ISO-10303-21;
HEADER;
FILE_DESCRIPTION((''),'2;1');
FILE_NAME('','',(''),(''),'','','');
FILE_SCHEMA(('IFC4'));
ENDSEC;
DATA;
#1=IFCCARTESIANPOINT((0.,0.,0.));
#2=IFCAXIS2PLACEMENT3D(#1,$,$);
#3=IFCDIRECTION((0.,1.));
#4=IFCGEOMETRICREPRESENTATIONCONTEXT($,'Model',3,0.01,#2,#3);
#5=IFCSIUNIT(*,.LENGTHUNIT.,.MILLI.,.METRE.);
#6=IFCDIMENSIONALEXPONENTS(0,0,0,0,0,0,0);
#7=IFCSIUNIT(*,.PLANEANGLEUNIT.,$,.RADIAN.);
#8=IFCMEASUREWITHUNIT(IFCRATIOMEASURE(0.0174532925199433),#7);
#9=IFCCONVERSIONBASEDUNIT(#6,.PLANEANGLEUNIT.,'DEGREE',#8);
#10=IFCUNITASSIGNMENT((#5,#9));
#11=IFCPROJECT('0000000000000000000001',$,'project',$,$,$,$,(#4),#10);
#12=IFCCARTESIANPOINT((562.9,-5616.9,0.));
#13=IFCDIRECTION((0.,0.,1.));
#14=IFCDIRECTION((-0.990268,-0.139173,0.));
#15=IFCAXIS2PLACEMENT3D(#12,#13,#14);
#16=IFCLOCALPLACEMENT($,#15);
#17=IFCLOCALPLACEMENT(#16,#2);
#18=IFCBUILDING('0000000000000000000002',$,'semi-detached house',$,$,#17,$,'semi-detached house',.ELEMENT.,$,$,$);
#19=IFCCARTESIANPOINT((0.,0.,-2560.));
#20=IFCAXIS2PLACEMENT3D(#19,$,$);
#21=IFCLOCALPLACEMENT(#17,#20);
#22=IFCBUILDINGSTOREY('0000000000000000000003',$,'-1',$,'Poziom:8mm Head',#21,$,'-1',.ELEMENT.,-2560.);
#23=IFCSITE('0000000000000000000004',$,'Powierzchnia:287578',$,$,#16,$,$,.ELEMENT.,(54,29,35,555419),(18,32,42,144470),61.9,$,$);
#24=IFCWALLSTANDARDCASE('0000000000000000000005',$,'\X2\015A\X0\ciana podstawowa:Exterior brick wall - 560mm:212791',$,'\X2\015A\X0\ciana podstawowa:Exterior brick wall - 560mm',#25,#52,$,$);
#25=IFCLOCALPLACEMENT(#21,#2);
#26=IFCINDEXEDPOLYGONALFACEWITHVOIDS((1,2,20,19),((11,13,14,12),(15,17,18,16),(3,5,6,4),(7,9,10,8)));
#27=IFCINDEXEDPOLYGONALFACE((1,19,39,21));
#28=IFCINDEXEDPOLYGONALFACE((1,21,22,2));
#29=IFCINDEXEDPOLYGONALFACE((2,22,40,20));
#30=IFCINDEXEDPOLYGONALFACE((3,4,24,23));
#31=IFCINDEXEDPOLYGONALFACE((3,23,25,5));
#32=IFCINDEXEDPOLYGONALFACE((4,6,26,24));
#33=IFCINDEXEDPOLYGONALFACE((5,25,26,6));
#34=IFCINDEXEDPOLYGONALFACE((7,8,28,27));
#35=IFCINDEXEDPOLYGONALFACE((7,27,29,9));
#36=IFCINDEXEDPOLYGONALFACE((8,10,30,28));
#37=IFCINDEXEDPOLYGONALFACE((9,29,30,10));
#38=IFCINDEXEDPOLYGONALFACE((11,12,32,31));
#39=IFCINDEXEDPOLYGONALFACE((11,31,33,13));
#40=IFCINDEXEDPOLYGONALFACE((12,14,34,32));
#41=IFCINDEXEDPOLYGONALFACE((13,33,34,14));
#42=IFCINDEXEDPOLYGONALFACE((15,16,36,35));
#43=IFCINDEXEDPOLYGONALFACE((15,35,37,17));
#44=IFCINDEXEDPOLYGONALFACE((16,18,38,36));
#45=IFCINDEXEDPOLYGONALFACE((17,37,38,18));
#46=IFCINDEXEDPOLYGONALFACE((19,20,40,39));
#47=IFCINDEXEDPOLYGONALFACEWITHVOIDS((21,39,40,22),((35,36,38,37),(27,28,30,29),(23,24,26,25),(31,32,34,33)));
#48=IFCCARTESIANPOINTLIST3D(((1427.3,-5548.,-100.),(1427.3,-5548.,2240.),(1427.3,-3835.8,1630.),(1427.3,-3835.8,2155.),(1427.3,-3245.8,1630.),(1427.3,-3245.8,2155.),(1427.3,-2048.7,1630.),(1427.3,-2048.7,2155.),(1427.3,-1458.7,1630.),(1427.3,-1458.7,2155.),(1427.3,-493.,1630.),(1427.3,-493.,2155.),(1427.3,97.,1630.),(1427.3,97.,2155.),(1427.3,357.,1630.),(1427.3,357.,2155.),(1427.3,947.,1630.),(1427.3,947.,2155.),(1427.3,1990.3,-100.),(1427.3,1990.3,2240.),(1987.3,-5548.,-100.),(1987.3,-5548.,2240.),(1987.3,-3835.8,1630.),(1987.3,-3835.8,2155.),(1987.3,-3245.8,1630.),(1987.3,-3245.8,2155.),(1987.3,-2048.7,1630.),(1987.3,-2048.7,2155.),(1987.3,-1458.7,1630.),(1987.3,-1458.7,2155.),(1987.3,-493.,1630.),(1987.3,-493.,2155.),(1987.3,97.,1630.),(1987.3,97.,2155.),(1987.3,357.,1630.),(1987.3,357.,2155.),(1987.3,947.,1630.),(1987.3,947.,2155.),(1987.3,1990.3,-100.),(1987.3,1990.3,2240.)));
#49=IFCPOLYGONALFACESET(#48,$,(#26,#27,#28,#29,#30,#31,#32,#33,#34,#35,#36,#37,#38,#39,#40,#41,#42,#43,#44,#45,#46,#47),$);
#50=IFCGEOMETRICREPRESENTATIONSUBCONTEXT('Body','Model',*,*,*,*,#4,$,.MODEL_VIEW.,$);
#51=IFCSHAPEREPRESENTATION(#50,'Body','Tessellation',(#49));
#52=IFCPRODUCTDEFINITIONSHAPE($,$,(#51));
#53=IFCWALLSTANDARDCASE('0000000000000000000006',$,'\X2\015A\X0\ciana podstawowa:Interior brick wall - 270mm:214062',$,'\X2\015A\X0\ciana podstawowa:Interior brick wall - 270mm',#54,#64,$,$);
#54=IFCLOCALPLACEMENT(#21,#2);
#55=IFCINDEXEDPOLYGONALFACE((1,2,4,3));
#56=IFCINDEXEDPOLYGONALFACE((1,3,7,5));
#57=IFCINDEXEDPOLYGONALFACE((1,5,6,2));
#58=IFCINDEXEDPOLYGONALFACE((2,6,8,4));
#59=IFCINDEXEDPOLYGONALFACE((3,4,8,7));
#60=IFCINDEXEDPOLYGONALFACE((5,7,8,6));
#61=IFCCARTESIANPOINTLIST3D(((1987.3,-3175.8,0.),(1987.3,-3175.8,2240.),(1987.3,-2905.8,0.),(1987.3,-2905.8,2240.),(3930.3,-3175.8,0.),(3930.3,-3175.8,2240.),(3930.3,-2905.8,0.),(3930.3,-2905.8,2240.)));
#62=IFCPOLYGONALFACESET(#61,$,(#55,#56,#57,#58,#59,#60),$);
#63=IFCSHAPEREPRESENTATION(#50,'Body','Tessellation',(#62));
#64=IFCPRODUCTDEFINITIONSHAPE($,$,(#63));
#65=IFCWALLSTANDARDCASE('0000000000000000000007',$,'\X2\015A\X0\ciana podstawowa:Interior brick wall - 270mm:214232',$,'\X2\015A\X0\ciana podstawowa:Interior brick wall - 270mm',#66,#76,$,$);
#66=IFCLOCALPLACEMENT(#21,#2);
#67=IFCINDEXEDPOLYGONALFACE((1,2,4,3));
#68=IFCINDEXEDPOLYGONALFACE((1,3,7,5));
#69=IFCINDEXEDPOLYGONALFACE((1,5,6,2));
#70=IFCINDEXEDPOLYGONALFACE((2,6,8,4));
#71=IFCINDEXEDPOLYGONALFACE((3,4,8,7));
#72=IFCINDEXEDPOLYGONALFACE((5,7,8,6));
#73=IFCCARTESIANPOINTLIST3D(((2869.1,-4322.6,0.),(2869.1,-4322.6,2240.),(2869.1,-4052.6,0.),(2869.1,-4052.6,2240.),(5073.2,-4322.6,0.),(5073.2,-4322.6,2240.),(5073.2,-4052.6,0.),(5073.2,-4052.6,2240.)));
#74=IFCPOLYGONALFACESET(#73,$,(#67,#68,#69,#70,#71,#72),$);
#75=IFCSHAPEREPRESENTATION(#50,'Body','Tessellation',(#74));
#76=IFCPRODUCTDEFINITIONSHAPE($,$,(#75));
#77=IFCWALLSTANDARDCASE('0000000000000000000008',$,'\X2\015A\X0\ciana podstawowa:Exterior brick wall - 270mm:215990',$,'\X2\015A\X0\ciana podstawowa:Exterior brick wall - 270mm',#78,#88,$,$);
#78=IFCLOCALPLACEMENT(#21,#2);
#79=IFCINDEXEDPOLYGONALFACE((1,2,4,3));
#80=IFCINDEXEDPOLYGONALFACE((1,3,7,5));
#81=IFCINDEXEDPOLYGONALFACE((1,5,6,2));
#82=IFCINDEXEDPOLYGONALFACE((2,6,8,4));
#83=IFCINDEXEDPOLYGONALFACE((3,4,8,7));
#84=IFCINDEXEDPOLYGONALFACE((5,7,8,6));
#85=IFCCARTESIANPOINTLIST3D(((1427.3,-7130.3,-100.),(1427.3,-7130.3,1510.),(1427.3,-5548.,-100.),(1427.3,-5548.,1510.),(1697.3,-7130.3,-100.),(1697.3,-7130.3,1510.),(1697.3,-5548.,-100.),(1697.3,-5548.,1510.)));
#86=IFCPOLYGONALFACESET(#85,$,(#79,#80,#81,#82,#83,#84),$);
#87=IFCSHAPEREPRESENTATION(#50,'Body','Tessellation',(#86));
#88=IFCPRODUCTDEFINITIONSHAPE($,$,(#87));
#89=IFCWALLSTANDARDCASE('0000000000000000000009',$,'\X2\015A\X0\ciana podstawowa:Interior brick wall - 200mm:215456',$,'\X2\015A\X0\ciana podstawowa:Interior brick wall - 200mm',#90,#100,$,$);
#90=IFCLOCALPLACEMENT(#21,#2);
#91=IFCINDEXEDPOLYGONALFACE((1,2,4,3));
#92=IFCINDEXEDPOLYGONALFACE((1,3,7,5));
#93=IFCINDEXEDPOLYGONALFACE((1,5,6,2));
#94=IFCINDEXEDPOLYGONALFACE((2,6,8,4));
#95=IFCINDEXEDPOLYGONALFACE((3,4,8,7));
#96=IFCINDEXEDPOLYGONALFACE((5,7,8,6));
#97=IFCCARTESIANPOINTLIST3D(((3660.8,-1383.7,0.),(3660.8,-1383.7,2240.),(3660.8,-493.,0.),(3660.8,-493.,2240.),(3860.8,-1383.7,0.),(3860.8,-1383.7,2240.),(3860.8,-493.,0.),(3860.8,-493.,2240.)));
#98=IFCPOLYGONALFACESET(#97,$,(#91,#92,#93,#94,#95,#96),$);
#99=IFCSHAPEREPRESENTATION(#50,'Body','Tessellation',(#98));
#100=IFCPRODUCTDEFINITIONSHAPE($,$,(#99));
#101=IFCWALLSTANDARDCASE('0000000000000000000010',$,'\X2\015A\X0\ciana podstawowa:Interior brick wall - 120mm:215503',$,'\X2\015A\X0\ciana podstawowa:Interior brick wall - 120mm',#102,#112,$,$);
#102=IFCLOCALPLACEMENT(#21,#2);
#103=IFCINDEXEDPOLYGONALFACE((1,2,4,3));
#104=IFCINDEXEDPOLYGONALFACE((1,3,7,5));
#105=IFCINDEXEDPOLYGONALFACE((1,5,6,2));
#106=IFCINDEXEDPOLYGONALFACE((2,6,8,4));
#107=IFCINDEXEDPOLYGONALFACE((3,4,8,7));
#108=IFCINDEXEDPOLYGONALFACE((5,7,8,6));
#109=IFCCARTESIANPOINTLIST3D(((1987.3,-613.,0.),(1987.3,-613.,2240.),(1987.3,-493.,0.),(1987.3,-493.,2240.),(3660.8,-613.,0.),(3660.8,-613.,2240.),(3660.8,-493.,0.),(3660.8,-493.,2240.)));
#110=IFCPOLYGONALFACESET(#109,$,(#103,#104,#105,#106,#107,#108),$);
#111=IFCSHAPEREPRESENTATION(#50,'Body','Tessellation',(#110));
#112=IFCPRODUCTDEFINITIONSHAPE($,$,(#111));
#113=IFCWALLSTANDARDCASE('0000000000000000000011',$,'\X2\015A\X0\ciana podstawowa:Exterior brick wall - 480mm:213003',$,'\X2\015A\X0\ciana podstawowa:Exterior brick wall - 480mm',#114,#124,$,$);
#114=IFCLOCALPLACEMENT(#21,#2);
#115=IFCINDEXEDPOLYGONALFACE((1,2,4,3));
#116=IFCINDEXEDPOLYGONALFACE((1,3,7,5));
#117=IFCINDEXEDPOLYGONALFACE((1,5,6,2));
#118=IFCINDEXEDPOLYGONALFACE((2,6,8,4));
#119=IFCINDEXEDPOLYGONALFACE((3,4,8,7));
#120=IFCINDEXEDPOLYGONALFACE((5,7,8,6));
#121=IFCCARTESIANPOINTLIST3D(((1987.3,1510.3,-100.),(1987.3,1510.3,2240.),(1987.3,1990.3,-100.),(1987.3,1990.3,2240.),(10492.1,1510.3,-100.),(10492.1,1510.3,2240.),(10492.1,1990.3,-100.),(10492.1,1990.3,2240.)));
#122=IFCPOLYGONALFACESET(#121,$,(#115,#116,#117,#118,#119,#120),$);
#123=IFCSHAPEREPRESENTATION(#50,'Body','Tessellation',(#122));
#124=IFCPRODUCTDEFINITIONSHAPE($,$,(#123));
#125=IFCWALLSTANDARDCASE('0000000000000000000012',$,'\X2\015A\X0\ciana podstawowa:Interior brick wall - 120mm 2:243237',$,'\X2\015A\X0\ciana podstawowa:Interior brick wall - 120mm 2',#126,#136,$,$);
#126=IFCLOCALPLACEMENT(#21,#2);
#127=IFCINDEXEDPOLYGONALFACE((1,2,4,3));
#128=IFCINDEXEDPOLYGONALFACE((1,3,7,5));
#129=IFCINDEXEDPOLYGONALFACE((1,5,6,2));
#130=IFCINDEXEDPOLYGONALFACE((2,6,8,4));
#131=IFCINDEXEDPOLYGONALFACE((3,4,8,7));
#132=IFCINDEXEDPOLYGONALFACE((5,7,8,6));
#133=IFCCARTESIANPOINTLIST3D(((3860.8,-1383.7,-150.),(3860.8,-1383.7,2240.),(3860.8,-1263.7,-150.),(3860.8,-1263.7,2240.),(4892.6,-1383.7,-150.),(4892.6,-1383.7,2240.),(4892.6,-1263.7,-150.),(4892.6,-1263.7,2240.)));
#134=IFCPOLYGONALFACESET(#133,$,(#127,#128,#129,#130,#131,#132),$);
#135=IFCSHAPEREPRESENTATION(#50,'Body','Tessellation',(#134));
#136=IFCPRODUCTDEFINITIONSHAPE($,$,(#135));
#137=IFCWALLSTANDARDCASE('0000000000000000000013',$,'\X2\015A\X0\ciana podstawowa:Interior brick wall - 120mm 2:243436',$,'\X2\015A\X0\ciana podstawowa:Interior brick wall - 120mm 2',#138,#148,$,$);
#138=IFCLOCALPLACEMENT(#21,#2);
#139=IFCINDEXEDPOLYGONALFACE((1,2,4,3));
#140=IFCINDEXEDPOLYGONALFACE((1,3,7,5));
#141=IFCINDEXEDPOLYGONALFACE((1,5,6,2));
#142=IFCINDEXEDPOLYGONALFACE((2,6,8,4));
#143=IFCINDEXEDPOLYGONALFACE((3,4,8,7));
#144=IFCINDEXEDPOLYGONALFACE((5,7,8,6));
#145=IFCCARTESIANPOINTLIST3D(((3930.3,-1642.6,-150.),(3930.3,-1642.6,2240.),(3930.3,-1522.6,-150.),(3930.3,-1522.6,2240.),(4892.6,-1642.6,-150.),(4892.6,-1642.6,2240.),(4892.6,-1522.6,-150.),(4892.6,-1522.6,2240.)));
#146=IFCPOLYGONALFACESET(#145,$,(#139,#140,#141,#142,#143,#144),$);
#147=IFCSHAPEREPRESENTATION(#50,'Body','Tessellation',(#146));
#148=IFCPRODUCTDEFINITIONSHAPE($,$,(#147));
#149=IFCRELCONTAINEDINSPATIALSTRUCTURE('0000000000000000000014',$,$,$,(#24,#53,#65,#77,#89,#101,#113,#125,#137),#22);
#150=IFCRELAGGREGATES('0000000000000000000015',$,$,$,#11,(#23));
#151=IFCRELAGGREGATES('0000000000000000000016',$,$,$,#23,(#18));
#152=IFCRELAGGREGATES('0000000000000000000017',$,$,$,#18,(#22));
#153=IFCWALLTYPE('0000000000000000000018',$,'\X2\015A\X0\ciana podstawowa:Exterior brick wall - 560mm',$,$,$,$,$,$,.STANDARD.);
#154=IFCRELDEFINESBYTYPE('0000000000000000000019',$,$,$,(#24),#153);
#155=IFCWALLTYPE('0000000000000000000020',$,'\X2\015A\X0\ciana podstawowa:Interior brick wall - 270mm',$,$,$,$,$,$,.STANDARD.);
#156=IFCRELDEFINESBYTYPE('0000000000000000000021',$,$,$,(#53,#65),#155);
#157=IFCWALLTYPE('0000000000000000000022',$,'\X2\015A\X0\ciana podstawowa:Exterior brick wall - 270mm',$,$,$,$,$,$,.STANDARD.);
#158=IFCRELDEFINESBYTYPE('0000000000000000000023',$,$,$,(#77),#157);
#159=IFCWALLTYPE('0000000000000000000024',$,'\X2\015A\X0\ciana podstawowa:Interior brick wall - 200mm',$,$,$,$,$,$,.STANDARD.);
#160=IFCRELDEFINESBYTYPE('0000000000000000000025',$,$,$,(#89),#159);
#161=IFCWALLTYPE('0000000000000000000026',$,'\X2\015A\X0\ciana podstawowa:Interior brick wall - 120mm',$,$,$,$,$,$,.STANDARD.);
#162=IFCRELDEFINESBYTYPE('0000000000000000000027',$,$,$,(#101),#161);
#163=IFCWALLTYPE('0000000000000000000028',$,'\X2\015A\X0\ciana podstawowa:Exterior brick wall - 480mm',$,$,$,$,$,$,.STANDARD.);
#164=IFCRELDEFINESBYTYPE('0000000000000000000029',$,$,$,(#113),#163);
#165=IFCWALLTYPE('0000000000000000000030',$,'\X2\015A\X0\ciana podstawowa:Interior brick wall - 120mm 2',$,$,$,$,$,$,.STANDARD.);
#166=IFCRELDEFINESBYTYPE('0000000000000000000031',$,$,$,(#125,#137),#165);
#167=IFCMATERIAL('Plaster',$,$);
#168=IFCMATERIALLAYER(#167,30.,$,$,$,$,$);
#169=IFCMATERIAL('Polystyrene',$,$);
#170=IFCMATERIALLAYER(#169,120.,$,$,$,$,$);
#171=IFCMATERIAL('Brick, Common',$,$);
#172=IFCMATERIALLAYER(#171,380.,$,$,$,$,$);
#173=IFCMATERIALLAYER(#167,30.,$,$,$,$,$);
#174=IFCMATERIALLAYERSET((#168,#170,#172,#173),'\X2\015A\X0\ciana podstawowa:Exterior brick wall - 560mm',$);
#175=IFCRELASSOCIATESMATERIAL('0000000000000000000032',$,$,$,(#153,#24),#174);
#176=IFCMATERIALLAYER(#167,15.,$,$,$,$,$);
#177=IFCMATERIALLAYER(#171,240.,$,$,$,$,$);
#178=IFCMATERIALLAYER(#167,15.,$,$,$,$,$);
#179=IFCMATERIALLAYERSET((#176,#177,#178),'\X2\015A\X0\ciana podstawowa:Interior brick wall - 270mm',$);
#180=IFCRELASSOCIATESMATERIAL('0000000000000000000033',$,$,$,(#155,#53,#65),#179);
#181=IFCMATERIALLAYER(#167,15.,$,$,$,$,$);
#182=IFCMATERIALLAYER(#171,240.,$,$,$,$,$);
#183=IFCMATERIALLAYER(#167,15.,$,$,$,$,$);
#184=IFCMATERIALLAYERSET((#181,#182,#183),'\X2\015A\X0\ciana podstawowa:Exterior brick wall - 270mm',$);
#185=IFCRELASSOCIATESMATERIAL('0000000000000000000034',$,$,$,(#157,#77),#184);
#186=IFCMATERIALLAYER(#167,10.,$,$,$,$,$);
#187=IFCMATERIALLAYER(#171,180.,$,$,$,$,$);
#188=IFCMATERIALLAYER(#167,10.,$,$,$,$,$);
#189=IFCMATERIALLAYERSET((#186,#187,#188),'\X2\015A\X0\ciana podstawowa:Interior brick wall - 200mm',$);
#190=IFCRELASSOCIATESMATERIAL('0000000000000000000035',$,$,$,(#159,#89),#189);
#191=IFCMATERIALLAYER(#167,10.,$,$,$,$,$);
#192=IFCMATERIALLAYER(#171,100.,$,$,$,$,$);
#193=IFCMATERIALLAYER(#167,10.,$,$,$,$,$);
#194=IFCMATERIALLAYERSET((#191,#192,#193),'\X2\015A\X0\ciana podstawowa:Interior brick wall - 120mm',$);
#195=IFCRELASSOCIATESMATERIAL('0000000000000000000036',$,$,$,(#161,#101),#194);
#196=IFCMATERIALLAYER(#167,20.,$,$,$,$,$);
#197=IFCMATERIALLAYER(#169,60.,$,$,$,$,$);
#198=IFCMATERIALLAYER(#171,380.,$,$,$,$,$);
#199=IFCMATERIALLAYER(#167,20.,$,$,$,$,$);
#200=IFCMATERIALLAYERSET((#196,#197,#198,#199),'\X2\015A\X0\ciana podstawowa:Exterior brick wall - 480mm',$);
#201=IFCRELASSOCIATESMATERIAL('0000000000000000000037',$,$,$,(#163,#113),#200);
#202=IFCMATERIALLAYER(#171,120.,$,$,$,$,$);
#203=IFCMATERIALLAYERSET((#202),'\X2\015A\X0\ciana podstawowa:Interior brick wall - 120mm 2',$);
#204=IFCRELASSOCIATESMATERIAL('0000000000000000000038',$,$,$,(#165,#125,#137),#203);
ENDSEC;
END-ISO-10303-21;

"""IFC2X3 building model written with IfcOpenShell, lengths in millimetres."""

from ifc_helpers import new_model, entity, si_unit, converted_unit, direction, frame, frame_2d, origin, place, context, subcontext, project, spatial, polyline, rectangle, extrude, clip, bounded_halfspace, material, layer, layer_set, layer_usage, type_object, element, save


model = new_model("IFC2X3")

# Units and contexts
model_context = context("Model", 3, precision=0.01, world=origin(), true_north=direction((0.0, 1.0)))
body_context = subcontext(model_context, "Body", "Model", "MODEL_VIEW")
ifc_project = project(units=[si_unit("LENGTHUNIT", "METRE", prefix="MILLI"), converted_unit("PLANEANGLEUNIT", "DEGREE", entity("IfcRatioMeasure", 0.0174532925199433), si_unit("PLANEANGLEUNIT", "RADIAN"), dimensions=[0, 0, 0, 0, 0, 0, 0])], contexts=[model_context])

# Site, building, storey
site_placement = place(None, frame((562.9, -5616.9, 0.0), z_axis=(0.0, 0.0, 1.0), x_axis=(-0.990268, -0.139173, 0.0)))
site = spatial("IfcSite", under=ifc_project, at=site_placement, Name="Powierzchnia:287578", CompositionType="ELEMENT", RefLatitude=(54, 29, 35, 555419), RefLongitude=(18, 32, 42, 144470), RefElevation=61.9)
building_placement = place(site_placement, origin())
building = spatial("IfcBuilding", under=site, at=building_placement, Name="semi-detached house", LongName="semi-detached house", CompositionType="ELEMENT")
storey_placement = place(building_placement, frame((0.0, 0.0, -2560.0)))
storey = spatial("IfcBuildingStorey", under=building, at=storey_placement, Name="-1", ObjectType="Poziom:8mm Head", LongName="-1", CompositionType="ELEMENT", Elevation=-2560.0)

# Wall, openings
ifc_material_1 = material(Name="Plaster")
ifc_layer_1 = layer(ifc_material_1, 30.0)
ifc_material_2 = material(Name="Polystyrene")
ifc_layer_2 = layer(ifc_material_2, 120.0)
ifc_material_3 = material(Name="Brick, Common")
ifc_layer_3 = layer(ifc_material_3, 380.0)
ifc_layer_4 = layer(ifc_material_1, 30.0)
ifc_layer_set_1 = layer_set([ifc_layer_1, ifc_layer_2, ifc_layer_3, ifc_layer_4], Name="Ściana podstawowa:Exterior brick wall - 560mm")
ifc_layer_usage_1 = layer_usage(ifc_layer_set_1, "AXIS2", "POSITIVE", -280.0)
wall_type_1 = type_object("IfcWallType", Name="Ściana podstawowa:Exterior brick wall - 560mm", PredefinedType="STANDARD", material=ifc_layer_set_1)
wall_1_placement = place(storey_placement, frame((1707.3, 1990.3, -100.0), z_axis=(0.0, 0.0, 1.0), x_axis=(0.0, -1.0, 0.0)))
wall_1 = element("IfcWallStandardCase", 1, at=wall_1_placement, inside=storey, type_object=wall_type_1, material=ifc_layer_usage_1, Name="Ściana podstawowa:Exterior brick wall - 560mm:212791", ObjectType="Ściana podstawowa:Exterior brick wall - 560mm", context=body_context, shape_type="SweptSolid", body=[
    extrude(rectangle(XDim=7538.3, YDim=560.0, at=frame_2d((3769.2, 0.0), x_axis=(-1.0, 0.0))), origin(), (0.0, 0.0, 1.0), 2340.0),
])
opening_1_placement = place(wall_1_placement, frame((5826.1, 280.0, 1730.0)))
element("IfcOpeningElement", 2, at=opening_1_placement, cuts=wall_1, ObjectType="Opening", context=body_context, shape_type="SweptSolid", body=[
    extrude(rectangle(XDim=525.0, YDim=590.0, at=frame_2d((262.5, 295.0), x_axis=(-1.0, 0.0))), frame((0.0, 0.0, 0.0), z_axis=(0.0, -1.0, 0.0), x_axis=(0.0, 0.0, 1.0)), (0.0, 0.0, 1.0), 560.0),
])
opening_2_placement = place(wall_1_placement, frame((4039.0, 280.0, 1730.0)))
element("IfcOpeningElement", 3, at=opening_2_placement, cuts=wall_1, ObjectType="Opening", context=body_context, shape_type="SweptSolid", body=[
    extrude(rectangle(XDim=525.0, YDim=590.0, at=frame_2d((262.5, 295.0), x_axis=(-1.0, 0.0))), frame((0.0, 0.0, 0.0), z_axis=(0.0, -1.0, 0.0), x_axis=(0.0, 0.0, 1.0)), (0.0, 0.0, 1.0), 560.0),
])
opening_3_placement = place(wall_1_placement, frame((2483.3, 280.0, 1730.0)))
element("IfcOpeningElement", 4, at=opening_3_placement, cuts=wall_1, ObjectType="Opening", context=body_context, shape_type="SweptSolid", body=[
    extrude(rectangle(XDim=525.0, YDim=590.0, at=frame_2d((262.5, 295.0), x_axis=(-1.0, 0.0))), frame((0.0, 0.0, 0.0), z_axis=(0.0, -1.0, 0.0), x_axis=(0.0, 0.0, 1.0)), (0.0, 0.0, 1.0), 560.0),
])
opening_4_placement = place(wall_1_placement, frame((1633.3, 280.0, 1730.0)))
element("IfcOpeningElement", 5, at=opening_4_placement, cuts=wall_1, ObjectType="Opening", context=body_context, shape_type="SweptSolid", body=[
    extrude(rectangle(XDim=525.0, YDim=590.0, at=frame_2d((262.5, 295.0), x_axis=(-1.0, 0.0))), frame((0.0, 0.0, 0.0), z_axis=(0.0, -1.0, 0.0), x_axis=(0.0, 0.0, 1.0)), (0.0, 0.0, 1.0), 560.0),
])

# Walls
ifc_layer_5 = layer(ifc_material_1, 15.0)
ifc_layer_6 = layer(ifc_material_3, 240.0)
ifc_layer_7 = layer(ifc_material_1, 15.0)
ifc_layer_set_2 = layer_set([ifc_layer_5, ifc_layer_6, ifc_layer_7], Name="Ściana podstawowa:Interior brick wall - 270mm")
ifc_layer_usage_2 = layer_usage(ifc_layer_set_2, "AXIS2", "POSITIVE", -135.0)
wall_type_2 = type_object("IfcWallType", Name="Ściana podstawowa:Interior brick wall - 270mm", PredefinedType="STANDARD", material=ifc_layer_set_2)
wall_2_placement = place(storey_placement, frame((1987.3, -3040.8, 0.0)))
element("IfcWallStandardCase", 6, at=wall_2_placement, inside=storey, type_object=wall_type_2, material=ifc_layer_usage_2, Name="Ściana podstawowa:Interior brick wall - 270mm:214062", ObjectType="Ściana podstawowa:Interior brick wall - 270mm", context=body_context, shape_type="Clipping", body=[
    clip(extrude(rectangle(XDim=1943.0, YDim=270.0, at=frame_2d((971.5, 0.0), x_axis=(-1.0, 0.0))), origin(), (0.0, 0.0, 1.0), 2240.0), bounded_halfspace(frame((1943.0, -135.0, 0.0), z_axis=(0.0, 0.0, 1.0), x_axis=(0.0, 1.0, 0.0)), True, frame((1943.0, -135.0, 0.0), z_axis=(0.0, 0.0, 1.0), x_axis=(0.0, 1.0, 0.0)), polyline([(0.0, 0.0), (270.0, 0.0), (270.0, 120.0), (270.0, 1943.0), (0.0, 1943.0), (0.0, 0.0)]))),
])
ifc_layer_usage_3 = layer_usage(ifc_layer_set_2, "AXIS2", "NEGATIVE", 135.0)
wall_3_placement = place(storey_placement, frame((2869.1, -4187.6, 0.0)))
element("IfcWallStandardCase", 7, at=wall_3_placement, inside=storey, type_object=wall_type_2, material=ifc_layer_usage_3, Name="Ściana podstawowa:Interior brick wall - 270mm:214232", ObjectType="Ściana podstawowa:Interior brick wall - 270mm", context=body_context, shape_type="Clipping", body=[
    clip(extrude(rectangle(XDim=2204.0, YDim=270.0, at=frame_2d((1102.0, 0.0), x_axis=(-1.0, 0.0))), origin(), (0.0, 0.0, 1.0), 2240.0), bounded_halfspace(frame((2204.0, -135.0, 0.0), z_axis=(0.0, 0.0, 1.0), x_axis=(0.0, 1.0, 0.0)), True, frame((2204.0, -135.0, 0.0), z_axis=(0.0, 0.0, 1.0), x_axis=(0.0, 1.0, 0.0)), polyline([(0.0, 0.0), (270.0, 0.0), (270.0, 2204.0), (0.0, 2204.0), (0.0, 0.0)]))),
])
ifc_layer_8 = layer(ifc_material_1, 15.0)
ifc_layer_9 = layer(ifc_material_3, 240.0)
ifc_layer_10 = layer(ifc_material_1, 15.0)
ifc_layer_set_3 = layer_set([ifc_layer_8, ifc_layer_9, ifc_layer_10], Name="Ściana podstawowa:Exterior brick wall - 270mm")
ifc_layer_usage_4 = layer_usage(ifc_layer_set_3, "AXIS2", "POSITIVE", -135.0)
wall_type_3 = type_object("IfcWallType", Name="Ściana podstawowa:Exterior brick wall - 270mm", PredefinedType="STANDARD", material=ifc_layer_set_3)
wall_4_placement = place(storey_placement, frame((1562.3, -5548.0, -100.0), z_axis=(0.0, 0.0, 1.0), x_axis=(0.0, -1.0, 0.0)))
element("IfcWallStandardCase", 8, at=wall_4_placement, inside=storey, type_object=wall_type_3, material=ifc_layer_usage_4, Name="Ściana podstawowa:Exterior brick wall - 270mm:215990", ObjectType="Ściana podstawowa:Exterior brick wall - 270mm", context=body_context, shape_type="Clipping", body=[
    clip(extrude(rectangle(XDim=1582.2, YDim=270.0, at=frame_2d((791.1, 0.0), x_axis=(-1.0, 0.0))), origin(), (0.0, 0.0, 1.0), 1610.0), bounded_halfspace(frame((0.5, -135.0, 1610.0), z_axis=(0.0, 0.0, -1.0), x_axis=(1.0, 0.0, 0.0)), True, frame((0.5, -135.0, 1610.0)), polyline([(0.0, 0.0), (1581.8, 0.0), (1581.8, 270.0), (1311.8, 270.0), (0.0, 270.0), (0.0, 0.0)]))),
])

# Walls
ifc_layer_11 = layer(ifc_material_1, 10.0)
ifc_layer_12 = layer(ifc_material_3, 180.0)
ifc_layer_13 = layer(ifc_material_1, 10.0)
ifc_layer_set_4 = layer_set([ifc_layer_11, ifc_layer_12, ifc_layer_13], Name="Ściana podstawowa:Interior brick wall - 200mm")
ifc_layer_usage_5 = layer_usage(ifc_layer_set_4, "AXIS2", "NEGATIVE", 100.0)
wall_type_4 = type_object("IfcWallType", Name="Ściana podstawowa:Interior brick wall - 200mm", PredefinedType="STANDARD", material=ifc_layer_set_4)
wall_5_placement = place(storey_placement, frame((3760.8, -1383.7, 0.0), z_axis=(0.0, 0.0, 1.0), x_axis=(0.0, 1.0, 0.0)))
element("IfcWallStandardCase", 9, at=wall_5_placement, inside=storey, type_object=wall_type_4, material=ifc_layer_usage_5, Name="Ściana podstawowa:Interior brick wall - 200mm:215456", ObjectType="Ściana podstawowa:Interior brick wall - 200mm", context=body_context, shape_type="Clipping", body=[
    clip(extrude(rectangle(XDim=890.8, YDim=200.0, at=frame_2d((445.4, 0.0), x_axis=(-1.0, 0.0))), origin(), (0.0, 0.0, 1.0), 2240.0), bounded_halfspace(frame((890.8, -100.0, 0.0)), True, frame((890.8, -100.0, 0.0)), polyline([(0.0, 0.0), (0.0, 120.0), (0.0, 200.0), (-120.0, 200.0), (-890.8, 200.0), (-890.8, 50.5), (-890.8, 0.0), (0.0, 0.0)]))),
])
ifc_layer_14 = layer(ifc_material_1, 10.0)
ifc_layer_15 = layer(ifc_material_3, 100.0)
ifc_layer_16 = layer(ifc_material_1, 10.0)
ifc_layer_set_5 = layer_set([ifc_layer_14, ifc_layer_15, ifc_layer_16], Name="Ściana podstawowa:Interior brick wall - 120mm")
ifc_layer_usage_6 = layer_usage(ifc_layer_set_5, "AXIS2", "NEGATIVE", 60.0)
wall_type_5 = type_object("IfcWallType", Name="Ściana podstawowa:Interior brick wall - 120mm", PredefinedType="STANDARD", material=ifc_layer_set_5)
wall_6_placement = place(storey_placement, frame((3660.8, -553.0, 0.0), z_axis=(0.0, 0.0, 1.0), x_axis=(-1.0, 0.0, 0.0)))
element("IfcWallStandardCase", 10, at=wall_6_placement, inside=storey, type_object=wall_type_5, material=ifc_layer_usage_6, Name="Ściana podstawowa:Interior brick wall - 120mm:215503", ObjectType="Ściana podstawowa:Interior brick wall - 120mm", context=body_context, shape_type="Clipping", body=[
    clip(extrude(rectangle(XDim=1673.5, YDim=120.0, at=frame_2d((836.8, 0.0), x_axis=(-1.0, 0.0))), origin(), (0.0, 0.0, 1.0), 2240.0), bounded_halfspace(frame((1673.5, -60.0, 0.0), z_axis=(0.0, 0.0, 1.0), x_axis=(0.0, -1.0, 0.0)), True, frame((1673.5, -60.0, 0.0), z_axis=(0.0, 0.0, 1.0), x_axis=(0.0, -1.0, 0.0)), polyline([(0.0, 0.0), (-120.0, 0.0), (-120.0, -1673.5), (0.0, -1673.5), (0.0, 0.0)]))),
])
ifc_layer_17 = layer(ifc_material_1, 20.0)
ifc_layer_18 = layer(ifc_material_2, 60.0)
ifc_layer_19 = layer(ifc_material_3, 380.0)
ifc_layer_20 = layer(ifc_material_1, 20.0)
ifc_layer_set_6 = layer_set([ifc_layer_17, ifc_layer_18, ifc_layer_19, ifc_layer_20], Name="Ściana podstawowa:Exterior brick wall - 480mm")
ifc_layer_usage_7 = layer_usage(ifc_layer_set_6, "AXIS2", "NEGATIVE", 240.0)
wall_type_6 = type_object("IfcWallType", Name="Ściana podstawowa:Exterior brick wall - 480mm", PredefinedType="STANDARD", material=ifc_layer_set_6)
wall_7_placement = place(storey_placement, frame((1987.3, 1750.3, -100.0)))
element("IfcWallStandardCase", 11, at=wall_7_placement, inside=storey, type_object=wall_type_6, material=ifc_layer_usage_7, Name="Ściana podstawowa:Exterior brick wall - 480mm:213003", ObjectType="Ściana podstawowa:Exterior brick wall - 480mm", context=body_context, shape_type="SweptSolid", body=[
    extrude(rectangle(XDim=8504.9, YDim=480.0, at=frame_2d((4252.4, 0.0), x_axis=(-1.0, 0.0))), origin(), (0.0, 0.0, 1.0), 2340.0),
])
ifc_layer_21 = layer(ifc_material_3, 120.0)
ifc_layer_set_7 = layer_set([ifc_layer_21], Name="Ściana podstawowa:Interior brick wall - 120mm 2")
ifc_layer_usage_8 = layer_usage(ifc_layer_set_7, "AXIS2", "NEGATIVE", 60.0)
wall_type_7 = type_object("IfcWallType", Name="Ściana podstawowa:Interior brick wall - 120mm 2", PredefinedType="STANDARD", material=ifc_layer_set_7)
wall_8_placement = place(storey_placement, frame((3860.8, -1323.7, -150.0)))
element("IfcWallStandardCase", 12, at=wall_8_placement, inside=storey, type_object=wall_type_7, material=ifc_layer_usage_8, Name="Ściana podstawowa:Interior brick wall - 120mm 2:243237", ObjectType="Ściana podstawowa:Interior brick wall - 120mm 2", context=body_context, shape_type="SweptSolid", body=[
    extrude(rectangle(XDim=1031.8, YDim=120.0, at=frame_2d((515.9, 0.0), x_axis=(-1.0, 0.0))), origin(), (0.0, 0.0, 1.0), 2390.0),
])
ifc_layer_usage_9 = layer_usage(ifc_layer_set_7, "AXIS2", "NEGATIVE", 60.0)
wall_9_placement = place(storey_placement, frame((3930.3, -1582.6, -150.0)))
element("IfcWallStandardCase", 13, at=wall_9_placement, inside=storey, type_object=wall_type_7, material=ifc_layer_usage_9, Name="Ściana podstawowa:Interior brick wall - 120mm 2:243436", ObjectType="Ściana podstawowa:Interior brick wall - 120mm 2", context=body_context, shape_type="SweptSolid", body=[
    extrude(rectangle(XDim=962.3, YDim=120.0, at=frame_2d((481.1, 0.0), x_axis=(-1.0, 0.0))), origin(), (0.0, 0.0, 1.0), 2390.0),
])

save(model, "model.ifc")
